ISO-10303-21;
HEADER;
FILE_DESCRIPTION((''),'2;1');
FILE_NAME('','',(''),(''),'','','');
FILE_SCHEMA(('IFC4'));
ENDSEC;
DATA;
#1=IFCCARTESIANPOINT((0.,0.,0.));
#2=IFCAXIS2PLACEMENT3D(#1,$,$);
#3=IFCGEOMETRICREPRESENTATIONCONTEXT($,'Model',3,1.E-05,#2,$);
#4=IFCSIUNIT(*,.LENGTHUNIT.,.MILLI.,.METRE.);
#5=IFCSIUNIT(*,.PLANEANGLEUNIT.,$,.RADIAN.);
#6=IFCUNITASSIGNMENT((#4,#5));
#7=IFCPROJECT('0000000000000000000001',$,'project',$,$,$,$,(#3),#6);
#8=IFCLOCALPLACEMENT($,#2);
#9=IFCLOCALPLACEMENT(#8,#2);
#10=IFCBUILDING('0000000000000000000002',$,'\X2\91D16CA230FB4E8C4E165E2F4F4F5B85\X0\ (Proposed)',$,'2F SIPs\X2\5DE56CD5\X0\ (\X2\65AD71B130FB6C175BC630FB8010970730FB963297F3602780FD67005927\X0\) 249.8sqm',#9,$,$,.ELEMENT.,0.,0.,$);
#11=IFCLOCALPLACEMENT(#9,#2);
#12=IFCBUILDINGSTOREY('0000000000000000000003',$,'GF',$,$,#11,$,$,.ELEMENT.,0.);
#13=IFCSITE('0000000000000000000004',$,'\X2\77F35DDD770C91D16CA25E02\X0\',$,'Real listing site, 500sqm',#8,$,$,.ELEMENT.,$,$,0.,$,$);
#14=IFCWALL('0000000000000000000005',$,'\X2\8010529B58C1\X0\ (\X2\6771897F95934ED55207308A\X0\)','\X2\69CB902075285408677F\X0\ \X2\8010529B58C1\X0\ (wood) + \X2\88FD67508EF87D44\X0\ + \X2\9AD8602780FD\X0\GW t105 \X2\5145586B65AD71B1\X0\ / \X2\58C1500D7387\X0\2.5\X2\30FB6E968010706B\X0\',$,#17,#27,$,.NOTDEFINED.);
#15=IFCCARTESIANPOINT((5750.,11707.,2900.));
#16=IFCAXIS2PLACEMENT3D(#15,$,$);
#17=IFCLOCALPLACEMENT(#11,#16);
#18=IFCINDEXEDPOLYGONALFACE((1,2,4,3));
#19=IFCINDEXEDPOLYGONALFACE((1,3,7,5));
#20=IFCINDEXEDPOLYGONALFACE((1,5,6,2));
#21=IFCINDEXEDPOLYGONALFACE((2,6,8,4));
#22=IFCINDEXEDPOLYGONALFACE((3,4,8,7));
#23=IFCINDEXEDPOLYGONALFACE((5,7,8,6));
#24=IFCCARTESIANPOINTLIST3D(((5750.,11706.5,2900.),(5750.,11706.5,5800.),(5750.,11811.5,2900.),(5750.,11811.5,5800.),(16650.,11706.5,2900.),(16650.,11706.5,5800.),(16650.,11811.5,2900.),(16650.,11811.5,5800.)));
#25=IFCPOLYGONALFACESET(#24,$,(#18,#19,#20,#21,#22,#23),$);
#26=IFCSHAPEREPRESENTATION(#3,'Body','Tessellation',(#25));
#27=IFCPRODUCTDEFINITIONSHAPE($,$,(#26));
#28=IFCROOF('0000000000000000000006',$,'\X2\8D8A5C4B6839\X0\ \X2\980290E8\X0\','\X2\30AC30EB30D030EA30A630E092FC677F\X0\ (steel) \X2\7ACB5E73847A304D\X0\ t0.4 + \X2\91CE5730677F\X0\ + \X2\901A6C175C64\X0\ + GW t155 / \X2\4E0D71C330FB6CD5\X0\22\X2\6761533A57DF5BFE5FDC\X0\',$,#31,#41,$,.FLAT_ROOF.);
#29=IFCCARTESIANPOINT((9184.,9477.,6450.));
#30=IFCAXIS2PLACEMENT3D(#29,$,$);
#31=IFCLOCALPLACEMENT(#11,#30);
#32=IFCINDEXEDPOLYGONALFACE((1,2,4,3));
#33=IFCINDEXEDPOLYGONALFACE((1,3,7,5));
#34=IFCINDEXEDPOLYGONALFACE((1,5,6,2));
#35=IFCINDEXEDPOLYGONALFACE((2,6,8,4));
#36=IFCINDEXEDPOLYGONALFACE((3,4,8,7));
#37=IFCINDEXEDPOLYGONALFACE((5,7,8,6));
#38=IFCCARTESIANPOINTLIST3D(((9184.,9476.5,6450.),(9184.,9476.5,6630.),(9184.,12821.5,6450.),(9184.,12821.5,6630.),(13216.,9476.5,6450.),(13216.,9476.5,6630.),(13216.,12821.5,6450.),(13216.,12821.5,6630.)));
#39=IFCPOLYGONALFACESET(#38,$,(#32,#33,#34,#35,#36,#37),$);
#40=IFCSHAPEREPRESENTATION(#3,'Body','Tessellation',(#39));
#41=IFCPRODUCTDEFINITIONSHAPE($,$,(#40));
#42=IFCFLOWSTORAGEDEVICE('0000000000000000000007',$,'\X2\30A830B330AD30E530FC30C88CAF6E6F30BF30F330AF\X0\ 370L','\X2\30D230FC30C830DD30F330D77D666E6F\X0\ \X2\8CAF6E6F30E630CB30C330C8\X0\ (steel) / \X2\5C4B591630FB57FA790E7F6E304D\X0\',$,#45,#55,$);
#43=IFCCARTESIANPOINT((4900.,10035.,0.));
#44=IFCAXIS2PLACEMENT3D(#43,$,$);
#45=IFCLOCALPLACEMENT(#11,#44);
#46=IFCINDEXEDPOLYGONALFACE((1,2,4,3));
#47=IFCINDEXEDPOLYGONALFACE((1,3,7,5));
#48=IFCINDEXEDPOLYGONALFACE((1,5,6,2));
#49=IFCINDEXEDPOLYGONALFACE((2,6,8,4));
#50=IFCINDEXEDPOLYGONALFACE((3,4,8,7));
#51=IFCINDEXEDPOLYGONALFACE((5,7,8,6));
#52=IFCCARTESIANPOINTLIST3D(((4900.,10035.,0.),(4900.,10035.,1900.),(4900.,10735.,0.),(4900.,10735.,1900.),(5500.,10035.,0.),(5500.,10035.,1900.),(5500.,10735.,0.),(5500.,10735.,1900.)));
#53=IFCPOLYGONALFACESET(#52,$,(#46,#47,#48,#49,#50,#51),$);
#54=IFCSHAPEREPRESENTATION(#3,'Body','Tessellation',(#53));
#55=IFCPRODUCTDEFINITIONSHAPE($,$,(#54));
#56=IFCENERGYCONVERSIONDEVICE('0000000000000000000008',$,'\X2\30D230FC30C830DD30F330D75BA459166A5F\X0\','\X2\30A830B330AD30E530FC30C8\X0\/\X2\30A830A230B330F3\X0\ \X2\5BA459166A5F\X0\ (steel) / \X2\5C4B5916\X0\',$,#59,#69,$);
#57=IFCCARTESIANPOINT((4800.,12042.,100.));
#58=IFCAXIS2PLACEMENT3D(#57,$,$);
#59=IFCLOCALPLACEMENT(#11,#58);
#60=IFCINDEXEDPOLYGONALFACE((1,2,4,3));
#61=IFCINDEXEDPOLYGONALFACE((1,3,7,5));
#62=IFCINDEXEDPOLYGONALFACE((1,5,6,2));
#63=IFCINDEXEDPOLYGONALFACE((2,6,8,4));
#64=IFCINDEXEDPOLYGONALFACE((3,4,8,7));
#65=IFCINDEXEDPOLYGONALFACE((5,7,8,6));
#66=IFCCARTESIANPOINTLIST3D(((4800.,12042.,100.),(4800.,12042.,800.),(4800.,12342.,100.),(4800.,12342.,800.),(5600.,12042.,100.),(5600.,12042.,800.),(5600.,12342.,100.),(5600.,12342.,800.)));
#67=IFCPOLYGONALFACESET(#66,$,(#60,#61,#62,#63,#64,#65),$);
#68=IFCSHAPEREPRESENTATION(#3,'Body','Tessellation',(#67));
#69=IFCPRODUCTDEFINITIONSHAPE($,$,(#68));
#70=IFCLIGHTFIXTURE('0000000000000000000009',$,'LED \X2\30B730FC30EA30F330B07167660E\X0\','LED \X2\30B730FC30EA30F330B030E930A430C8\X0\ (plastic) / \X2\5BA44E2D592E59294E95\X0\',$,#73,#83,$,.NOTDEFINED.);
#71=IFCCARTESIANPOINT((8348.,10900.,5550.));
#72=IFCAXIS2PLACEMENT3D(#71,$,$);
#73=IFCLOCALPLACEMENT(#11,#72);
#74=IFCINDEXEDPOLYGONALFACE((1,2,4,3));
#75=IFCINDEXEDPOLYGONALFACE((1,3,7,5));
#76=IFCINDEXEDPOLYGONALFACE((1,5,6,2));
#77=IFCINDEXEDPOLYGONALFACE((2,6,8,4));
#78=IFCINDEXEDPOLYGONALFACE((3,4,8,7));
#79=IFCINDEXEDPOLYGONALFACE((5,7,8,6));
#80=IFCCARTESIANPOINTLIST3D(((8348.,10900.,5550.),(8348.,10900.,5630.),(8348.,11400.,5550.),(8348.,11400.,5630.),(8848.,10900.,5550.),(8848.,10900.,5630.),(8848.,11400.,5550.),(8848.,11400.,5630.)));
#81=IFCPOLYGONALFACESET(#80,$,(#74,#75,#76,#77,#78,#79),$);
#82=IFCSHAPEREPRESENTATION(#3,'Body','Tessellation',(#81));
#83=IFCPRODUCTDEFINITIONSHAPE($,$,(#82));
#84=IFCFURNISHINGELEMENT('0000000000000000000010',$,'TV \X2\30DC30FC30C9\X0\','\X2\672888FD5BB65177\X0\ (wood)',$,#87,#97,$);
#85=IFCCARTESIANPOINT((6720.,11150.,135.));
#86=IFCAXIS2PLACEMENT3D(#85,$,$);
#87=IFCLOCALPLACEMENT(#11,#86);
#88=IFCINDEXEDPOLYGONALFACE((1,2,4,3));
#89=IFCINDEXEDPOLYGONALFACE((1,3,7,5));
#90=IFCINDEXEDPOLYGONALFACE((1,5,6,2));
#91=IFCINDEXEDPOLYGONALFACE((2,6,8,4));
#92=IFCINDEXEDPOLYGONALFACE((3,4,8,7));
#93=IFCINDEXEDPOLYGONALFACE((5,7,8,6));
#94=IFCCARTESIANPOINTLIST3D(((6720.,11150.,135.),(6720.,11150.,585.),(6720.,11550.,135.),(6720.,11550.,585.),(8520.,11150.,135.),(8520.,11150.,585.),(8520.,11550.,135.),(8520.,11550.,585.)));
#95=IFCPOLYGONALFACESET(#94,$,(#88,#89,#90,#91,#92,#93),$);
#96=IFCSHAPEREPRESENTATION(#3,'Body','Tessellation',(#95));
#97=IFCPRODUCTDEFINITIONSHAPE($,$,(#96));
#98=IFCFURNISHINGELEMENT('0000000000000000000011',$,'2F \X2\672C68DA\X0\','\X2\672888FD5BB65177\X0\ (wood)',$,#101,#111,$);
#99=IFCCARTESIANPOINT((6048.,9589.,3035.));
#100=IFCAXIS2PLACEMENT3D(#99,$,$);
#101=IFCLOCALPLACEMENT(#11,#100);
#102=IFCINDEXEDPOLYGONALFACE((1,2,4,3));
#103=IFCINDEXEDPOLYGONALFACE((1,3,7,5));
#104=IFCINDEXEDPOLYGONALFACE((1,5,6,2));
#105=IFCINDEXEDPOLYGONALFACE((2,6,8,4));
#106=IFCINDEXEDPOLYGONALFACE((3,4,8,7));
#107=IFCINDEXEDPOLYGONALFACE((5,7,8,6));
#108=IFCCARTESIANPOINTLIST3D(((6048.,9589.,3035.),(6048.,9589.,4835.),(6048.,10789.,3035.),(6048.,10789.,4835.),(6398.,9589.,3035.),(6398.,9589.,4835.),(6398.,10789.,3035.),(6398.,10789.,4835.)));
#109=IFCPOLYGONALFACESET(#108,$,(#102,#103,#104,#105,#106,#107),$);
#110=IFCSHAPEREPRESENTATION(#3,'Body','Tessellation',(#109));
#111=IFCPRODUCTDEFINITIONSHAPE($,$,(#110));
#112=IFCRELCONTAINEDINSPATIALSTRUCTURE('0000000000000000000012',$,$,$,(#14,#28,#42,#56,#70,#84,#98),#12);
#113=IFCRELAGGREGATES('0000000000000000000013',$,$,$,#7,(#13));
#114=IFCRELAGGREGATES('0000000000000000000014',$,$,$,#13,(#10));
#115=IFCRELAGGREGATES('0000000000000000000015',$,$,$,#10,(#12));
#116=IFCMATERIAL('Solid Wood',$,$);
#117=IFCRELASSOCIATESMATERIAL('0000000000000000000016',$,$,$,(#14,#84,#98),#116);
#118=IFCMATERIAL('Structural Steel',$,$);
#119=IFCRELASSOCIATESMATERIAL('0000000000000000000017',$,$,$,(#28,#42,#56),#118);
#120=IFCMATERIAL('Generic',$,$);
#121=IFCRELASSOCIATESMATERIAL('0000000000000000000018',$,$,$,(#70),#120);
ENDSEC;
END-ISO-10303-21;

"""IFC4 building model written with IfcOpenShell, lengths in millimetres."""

from ifc_helpers import new_model, si_unit, frame, frame_2d, origin, place, context, project, spatial, rectangle, extrude, material, element, save


model = new_model("IFC4")

# Units and contexts
model_context = context("Model", 3, precision=1e-05, world=origin())
ifc_project = project(units=[si_unit("LENGTHUNIT", "METRE", prefix="MILLI"), si_unit("PLANEANGLEUNIT", "RADIAN")], contexts=[model_context])

# Site, building, storey
site_placement = place(None, origin())
site = spatial("IfcSite", under=ifc_project, at=site_placement, Name="石川県金沢市", ObjectType="Real listing site, 500sqm", CompositionType="ELEMENT", RefElevation=0.0)
building_placement = place(site_placement, origin())
building = spatial("IfcBuilding", under=site, at=building_placement, Name="金沢・二世帯住宅 (Proposed)", ObjectType="2F SIPs工法 (断熱・気密・耐震・防音性能最大) 249.8sqm", CompositionType="ELEMENT", ElevationOfRefHeight=0.0, ElevationOfTerrain=0.0)
storey_placement = place(building_placement, origin())
storey = spatial("IfcBuildingStorey", under=building, at=storey_placement, Name="GF", CompositionType="ELEMENT", Elevation=0.0)

# Shared definitions
ifc_material_1 = material(Name="Solid Wood")

# Wall
wall_1_placement = place(storey_placement, frame((5750.0, 11707.0, 2900.0)))
element("IfcWall", 1, at=wall_1_placement, inside=storey, material=ifc_material_1, Name="耐力壁 (東西間仕切り)", Description="構造用合板 耐力壁 (wood) + 製材軸組 + 高性能GW t105 充填断熱 / 壁倍率2.5・準耐火", PredefinedType="NOTDEFINED", context=model_context, shape_type="SweptSolid", body=[
    extrude(rectangle(XDim=10900.0, YDim=105.0, at=frame_2d((5450.0, 52.0))), frame((5750.0, 11707.0, 2900.0)), (0.0, 0.0, 1.0), 2900.0),
])

# Roof
ifc_material_2 = material(Name="Structural Steel")
roof_placement = place(storey_placement, frame((9184.0, 9477.0, 6450.0)))
element("IfcRoof", 2, at=roof_placement, inside=storey, material=ifc_material_2, Name="越屋根 頂部", Description="ガルバリウム鋼板 (steel) 立平葺き t0.4 + 野地板 + 通気層 + GW t155 / 不燃・法22条区域対応", PredefinedType="FLAT_ROOF", context=model_context, shape_type="SweptSolid", body=[
    extrude(rectangle(XDim=4032.0, YDim=3345.0, at=frame_2d((2016.0, 1672.0))), frame((9184.0, 9477.0, 6450.0)), (0.0, 0.0, 1.0), 180.0),
])

# Flow storage device
flow_storage_device_placement = place(storey_placement, frame((4900.0, 10035.0, 0.0)))
element("IfcFlowStorageDevice", 3, at=flow_storage_device_placement, inside=storey, material=ifc_material_2, Name="エコキュート貯湯タンク 370L", Description="ヒートポンプ給湯 貯湯ユニット (steel) / 屋外・基礎置き", context=model_context, shape_type="SweptSolid", body=[
    extrude(rectangle(XDim=600.0, YDim=700.0, at=frame_2d((300.0, 350.0))), frame((4900.0, 10035.0, 0.0)), (0.0, 0.0, 1.0), 1900.0),
])

# Energy conversion device
energy_conversion_device_placement = place(storey_placement, frame((4800.0, 12042.0, 100.0)))
element("IfcEnergyConversionDevice", 4, at=energy_conversion_device_placement, inside=storey, material=ifc_material_2, Name="ヒートポンプ室外機", Description="エコキュート/エアコン 室外機 (steel) / 屋外", context=model_context, shape_type="SweptSolid", body=[
    extrude(rectangle(XDim=800.0, YDim=300.0, at=frame_2d((400.0, 150.0))), frame((4800.0, 12042.0, 100.0)), (0.0, 0.0, 1.0), 700.0),
])

# Light fixture
ifc_material_3 = material(Name="Generic")
light_fixture_placement = place(storey_placement, frame((8348.0, 10900.0, 5550.0)))
element("IfcLightFixture", 5, at=light_fixture_placement, inside=storey, material=ifc_material_3, Name="LED シーリング照明", Description="LED シーリングライト (plastic) / 室中央天井", PredefinedType="NOTDEFINED", context=model_context, shape_type="SweptSolid", body=[
    extrude(rectangle(XDim=500.0, YDim=500.0, at=frame_2d((250.0, 250.0))), frame((8348.0, 10900.0, 5550.0)), (0.0, 0.0, 1.0), 80.0),
])

# Furnishing elements
furnishing_1_placement = place(storey_placement, frame((6720.0, 11150.0, 135.0)))
element("IfcFurnishingElement", 6, at=furnishing_1_placement, inside=storey, material=ifc_material_1, Name="TV ボード", Description="木製家具 (wood)", context=model_context, shape_type="SweptSolid", body=[
    extrude(rectangle(XDim=1800.0, YDim=400.0, at=frame_2d((900.0, 200.0))), frame((6720.0, 11150.0, 135.0)), (0.0, 0.0, 1.0), 450.0),
])
furnishing_2_placement = place(storey_placement, frame((6048.0, 9589.0, 3035.0)))
element("IfcFurnishingElement", 7, at=furnishing_2_placement, inside=storey, material=ifc_material_1, Name="2F 本棚", Description="木製家具 (wood)", context=model_context, shape_type="SweptSolid", body=[
    extrude(rectangle(XDim=350.0, YDim=1200.0, at=frame_2d((175.0, 600.0))), frame((6048.0, 9589.0, 3035.0)), (0.0, 0.0, 1.0), 1800.0),
])

save(model, "model.ifc")
